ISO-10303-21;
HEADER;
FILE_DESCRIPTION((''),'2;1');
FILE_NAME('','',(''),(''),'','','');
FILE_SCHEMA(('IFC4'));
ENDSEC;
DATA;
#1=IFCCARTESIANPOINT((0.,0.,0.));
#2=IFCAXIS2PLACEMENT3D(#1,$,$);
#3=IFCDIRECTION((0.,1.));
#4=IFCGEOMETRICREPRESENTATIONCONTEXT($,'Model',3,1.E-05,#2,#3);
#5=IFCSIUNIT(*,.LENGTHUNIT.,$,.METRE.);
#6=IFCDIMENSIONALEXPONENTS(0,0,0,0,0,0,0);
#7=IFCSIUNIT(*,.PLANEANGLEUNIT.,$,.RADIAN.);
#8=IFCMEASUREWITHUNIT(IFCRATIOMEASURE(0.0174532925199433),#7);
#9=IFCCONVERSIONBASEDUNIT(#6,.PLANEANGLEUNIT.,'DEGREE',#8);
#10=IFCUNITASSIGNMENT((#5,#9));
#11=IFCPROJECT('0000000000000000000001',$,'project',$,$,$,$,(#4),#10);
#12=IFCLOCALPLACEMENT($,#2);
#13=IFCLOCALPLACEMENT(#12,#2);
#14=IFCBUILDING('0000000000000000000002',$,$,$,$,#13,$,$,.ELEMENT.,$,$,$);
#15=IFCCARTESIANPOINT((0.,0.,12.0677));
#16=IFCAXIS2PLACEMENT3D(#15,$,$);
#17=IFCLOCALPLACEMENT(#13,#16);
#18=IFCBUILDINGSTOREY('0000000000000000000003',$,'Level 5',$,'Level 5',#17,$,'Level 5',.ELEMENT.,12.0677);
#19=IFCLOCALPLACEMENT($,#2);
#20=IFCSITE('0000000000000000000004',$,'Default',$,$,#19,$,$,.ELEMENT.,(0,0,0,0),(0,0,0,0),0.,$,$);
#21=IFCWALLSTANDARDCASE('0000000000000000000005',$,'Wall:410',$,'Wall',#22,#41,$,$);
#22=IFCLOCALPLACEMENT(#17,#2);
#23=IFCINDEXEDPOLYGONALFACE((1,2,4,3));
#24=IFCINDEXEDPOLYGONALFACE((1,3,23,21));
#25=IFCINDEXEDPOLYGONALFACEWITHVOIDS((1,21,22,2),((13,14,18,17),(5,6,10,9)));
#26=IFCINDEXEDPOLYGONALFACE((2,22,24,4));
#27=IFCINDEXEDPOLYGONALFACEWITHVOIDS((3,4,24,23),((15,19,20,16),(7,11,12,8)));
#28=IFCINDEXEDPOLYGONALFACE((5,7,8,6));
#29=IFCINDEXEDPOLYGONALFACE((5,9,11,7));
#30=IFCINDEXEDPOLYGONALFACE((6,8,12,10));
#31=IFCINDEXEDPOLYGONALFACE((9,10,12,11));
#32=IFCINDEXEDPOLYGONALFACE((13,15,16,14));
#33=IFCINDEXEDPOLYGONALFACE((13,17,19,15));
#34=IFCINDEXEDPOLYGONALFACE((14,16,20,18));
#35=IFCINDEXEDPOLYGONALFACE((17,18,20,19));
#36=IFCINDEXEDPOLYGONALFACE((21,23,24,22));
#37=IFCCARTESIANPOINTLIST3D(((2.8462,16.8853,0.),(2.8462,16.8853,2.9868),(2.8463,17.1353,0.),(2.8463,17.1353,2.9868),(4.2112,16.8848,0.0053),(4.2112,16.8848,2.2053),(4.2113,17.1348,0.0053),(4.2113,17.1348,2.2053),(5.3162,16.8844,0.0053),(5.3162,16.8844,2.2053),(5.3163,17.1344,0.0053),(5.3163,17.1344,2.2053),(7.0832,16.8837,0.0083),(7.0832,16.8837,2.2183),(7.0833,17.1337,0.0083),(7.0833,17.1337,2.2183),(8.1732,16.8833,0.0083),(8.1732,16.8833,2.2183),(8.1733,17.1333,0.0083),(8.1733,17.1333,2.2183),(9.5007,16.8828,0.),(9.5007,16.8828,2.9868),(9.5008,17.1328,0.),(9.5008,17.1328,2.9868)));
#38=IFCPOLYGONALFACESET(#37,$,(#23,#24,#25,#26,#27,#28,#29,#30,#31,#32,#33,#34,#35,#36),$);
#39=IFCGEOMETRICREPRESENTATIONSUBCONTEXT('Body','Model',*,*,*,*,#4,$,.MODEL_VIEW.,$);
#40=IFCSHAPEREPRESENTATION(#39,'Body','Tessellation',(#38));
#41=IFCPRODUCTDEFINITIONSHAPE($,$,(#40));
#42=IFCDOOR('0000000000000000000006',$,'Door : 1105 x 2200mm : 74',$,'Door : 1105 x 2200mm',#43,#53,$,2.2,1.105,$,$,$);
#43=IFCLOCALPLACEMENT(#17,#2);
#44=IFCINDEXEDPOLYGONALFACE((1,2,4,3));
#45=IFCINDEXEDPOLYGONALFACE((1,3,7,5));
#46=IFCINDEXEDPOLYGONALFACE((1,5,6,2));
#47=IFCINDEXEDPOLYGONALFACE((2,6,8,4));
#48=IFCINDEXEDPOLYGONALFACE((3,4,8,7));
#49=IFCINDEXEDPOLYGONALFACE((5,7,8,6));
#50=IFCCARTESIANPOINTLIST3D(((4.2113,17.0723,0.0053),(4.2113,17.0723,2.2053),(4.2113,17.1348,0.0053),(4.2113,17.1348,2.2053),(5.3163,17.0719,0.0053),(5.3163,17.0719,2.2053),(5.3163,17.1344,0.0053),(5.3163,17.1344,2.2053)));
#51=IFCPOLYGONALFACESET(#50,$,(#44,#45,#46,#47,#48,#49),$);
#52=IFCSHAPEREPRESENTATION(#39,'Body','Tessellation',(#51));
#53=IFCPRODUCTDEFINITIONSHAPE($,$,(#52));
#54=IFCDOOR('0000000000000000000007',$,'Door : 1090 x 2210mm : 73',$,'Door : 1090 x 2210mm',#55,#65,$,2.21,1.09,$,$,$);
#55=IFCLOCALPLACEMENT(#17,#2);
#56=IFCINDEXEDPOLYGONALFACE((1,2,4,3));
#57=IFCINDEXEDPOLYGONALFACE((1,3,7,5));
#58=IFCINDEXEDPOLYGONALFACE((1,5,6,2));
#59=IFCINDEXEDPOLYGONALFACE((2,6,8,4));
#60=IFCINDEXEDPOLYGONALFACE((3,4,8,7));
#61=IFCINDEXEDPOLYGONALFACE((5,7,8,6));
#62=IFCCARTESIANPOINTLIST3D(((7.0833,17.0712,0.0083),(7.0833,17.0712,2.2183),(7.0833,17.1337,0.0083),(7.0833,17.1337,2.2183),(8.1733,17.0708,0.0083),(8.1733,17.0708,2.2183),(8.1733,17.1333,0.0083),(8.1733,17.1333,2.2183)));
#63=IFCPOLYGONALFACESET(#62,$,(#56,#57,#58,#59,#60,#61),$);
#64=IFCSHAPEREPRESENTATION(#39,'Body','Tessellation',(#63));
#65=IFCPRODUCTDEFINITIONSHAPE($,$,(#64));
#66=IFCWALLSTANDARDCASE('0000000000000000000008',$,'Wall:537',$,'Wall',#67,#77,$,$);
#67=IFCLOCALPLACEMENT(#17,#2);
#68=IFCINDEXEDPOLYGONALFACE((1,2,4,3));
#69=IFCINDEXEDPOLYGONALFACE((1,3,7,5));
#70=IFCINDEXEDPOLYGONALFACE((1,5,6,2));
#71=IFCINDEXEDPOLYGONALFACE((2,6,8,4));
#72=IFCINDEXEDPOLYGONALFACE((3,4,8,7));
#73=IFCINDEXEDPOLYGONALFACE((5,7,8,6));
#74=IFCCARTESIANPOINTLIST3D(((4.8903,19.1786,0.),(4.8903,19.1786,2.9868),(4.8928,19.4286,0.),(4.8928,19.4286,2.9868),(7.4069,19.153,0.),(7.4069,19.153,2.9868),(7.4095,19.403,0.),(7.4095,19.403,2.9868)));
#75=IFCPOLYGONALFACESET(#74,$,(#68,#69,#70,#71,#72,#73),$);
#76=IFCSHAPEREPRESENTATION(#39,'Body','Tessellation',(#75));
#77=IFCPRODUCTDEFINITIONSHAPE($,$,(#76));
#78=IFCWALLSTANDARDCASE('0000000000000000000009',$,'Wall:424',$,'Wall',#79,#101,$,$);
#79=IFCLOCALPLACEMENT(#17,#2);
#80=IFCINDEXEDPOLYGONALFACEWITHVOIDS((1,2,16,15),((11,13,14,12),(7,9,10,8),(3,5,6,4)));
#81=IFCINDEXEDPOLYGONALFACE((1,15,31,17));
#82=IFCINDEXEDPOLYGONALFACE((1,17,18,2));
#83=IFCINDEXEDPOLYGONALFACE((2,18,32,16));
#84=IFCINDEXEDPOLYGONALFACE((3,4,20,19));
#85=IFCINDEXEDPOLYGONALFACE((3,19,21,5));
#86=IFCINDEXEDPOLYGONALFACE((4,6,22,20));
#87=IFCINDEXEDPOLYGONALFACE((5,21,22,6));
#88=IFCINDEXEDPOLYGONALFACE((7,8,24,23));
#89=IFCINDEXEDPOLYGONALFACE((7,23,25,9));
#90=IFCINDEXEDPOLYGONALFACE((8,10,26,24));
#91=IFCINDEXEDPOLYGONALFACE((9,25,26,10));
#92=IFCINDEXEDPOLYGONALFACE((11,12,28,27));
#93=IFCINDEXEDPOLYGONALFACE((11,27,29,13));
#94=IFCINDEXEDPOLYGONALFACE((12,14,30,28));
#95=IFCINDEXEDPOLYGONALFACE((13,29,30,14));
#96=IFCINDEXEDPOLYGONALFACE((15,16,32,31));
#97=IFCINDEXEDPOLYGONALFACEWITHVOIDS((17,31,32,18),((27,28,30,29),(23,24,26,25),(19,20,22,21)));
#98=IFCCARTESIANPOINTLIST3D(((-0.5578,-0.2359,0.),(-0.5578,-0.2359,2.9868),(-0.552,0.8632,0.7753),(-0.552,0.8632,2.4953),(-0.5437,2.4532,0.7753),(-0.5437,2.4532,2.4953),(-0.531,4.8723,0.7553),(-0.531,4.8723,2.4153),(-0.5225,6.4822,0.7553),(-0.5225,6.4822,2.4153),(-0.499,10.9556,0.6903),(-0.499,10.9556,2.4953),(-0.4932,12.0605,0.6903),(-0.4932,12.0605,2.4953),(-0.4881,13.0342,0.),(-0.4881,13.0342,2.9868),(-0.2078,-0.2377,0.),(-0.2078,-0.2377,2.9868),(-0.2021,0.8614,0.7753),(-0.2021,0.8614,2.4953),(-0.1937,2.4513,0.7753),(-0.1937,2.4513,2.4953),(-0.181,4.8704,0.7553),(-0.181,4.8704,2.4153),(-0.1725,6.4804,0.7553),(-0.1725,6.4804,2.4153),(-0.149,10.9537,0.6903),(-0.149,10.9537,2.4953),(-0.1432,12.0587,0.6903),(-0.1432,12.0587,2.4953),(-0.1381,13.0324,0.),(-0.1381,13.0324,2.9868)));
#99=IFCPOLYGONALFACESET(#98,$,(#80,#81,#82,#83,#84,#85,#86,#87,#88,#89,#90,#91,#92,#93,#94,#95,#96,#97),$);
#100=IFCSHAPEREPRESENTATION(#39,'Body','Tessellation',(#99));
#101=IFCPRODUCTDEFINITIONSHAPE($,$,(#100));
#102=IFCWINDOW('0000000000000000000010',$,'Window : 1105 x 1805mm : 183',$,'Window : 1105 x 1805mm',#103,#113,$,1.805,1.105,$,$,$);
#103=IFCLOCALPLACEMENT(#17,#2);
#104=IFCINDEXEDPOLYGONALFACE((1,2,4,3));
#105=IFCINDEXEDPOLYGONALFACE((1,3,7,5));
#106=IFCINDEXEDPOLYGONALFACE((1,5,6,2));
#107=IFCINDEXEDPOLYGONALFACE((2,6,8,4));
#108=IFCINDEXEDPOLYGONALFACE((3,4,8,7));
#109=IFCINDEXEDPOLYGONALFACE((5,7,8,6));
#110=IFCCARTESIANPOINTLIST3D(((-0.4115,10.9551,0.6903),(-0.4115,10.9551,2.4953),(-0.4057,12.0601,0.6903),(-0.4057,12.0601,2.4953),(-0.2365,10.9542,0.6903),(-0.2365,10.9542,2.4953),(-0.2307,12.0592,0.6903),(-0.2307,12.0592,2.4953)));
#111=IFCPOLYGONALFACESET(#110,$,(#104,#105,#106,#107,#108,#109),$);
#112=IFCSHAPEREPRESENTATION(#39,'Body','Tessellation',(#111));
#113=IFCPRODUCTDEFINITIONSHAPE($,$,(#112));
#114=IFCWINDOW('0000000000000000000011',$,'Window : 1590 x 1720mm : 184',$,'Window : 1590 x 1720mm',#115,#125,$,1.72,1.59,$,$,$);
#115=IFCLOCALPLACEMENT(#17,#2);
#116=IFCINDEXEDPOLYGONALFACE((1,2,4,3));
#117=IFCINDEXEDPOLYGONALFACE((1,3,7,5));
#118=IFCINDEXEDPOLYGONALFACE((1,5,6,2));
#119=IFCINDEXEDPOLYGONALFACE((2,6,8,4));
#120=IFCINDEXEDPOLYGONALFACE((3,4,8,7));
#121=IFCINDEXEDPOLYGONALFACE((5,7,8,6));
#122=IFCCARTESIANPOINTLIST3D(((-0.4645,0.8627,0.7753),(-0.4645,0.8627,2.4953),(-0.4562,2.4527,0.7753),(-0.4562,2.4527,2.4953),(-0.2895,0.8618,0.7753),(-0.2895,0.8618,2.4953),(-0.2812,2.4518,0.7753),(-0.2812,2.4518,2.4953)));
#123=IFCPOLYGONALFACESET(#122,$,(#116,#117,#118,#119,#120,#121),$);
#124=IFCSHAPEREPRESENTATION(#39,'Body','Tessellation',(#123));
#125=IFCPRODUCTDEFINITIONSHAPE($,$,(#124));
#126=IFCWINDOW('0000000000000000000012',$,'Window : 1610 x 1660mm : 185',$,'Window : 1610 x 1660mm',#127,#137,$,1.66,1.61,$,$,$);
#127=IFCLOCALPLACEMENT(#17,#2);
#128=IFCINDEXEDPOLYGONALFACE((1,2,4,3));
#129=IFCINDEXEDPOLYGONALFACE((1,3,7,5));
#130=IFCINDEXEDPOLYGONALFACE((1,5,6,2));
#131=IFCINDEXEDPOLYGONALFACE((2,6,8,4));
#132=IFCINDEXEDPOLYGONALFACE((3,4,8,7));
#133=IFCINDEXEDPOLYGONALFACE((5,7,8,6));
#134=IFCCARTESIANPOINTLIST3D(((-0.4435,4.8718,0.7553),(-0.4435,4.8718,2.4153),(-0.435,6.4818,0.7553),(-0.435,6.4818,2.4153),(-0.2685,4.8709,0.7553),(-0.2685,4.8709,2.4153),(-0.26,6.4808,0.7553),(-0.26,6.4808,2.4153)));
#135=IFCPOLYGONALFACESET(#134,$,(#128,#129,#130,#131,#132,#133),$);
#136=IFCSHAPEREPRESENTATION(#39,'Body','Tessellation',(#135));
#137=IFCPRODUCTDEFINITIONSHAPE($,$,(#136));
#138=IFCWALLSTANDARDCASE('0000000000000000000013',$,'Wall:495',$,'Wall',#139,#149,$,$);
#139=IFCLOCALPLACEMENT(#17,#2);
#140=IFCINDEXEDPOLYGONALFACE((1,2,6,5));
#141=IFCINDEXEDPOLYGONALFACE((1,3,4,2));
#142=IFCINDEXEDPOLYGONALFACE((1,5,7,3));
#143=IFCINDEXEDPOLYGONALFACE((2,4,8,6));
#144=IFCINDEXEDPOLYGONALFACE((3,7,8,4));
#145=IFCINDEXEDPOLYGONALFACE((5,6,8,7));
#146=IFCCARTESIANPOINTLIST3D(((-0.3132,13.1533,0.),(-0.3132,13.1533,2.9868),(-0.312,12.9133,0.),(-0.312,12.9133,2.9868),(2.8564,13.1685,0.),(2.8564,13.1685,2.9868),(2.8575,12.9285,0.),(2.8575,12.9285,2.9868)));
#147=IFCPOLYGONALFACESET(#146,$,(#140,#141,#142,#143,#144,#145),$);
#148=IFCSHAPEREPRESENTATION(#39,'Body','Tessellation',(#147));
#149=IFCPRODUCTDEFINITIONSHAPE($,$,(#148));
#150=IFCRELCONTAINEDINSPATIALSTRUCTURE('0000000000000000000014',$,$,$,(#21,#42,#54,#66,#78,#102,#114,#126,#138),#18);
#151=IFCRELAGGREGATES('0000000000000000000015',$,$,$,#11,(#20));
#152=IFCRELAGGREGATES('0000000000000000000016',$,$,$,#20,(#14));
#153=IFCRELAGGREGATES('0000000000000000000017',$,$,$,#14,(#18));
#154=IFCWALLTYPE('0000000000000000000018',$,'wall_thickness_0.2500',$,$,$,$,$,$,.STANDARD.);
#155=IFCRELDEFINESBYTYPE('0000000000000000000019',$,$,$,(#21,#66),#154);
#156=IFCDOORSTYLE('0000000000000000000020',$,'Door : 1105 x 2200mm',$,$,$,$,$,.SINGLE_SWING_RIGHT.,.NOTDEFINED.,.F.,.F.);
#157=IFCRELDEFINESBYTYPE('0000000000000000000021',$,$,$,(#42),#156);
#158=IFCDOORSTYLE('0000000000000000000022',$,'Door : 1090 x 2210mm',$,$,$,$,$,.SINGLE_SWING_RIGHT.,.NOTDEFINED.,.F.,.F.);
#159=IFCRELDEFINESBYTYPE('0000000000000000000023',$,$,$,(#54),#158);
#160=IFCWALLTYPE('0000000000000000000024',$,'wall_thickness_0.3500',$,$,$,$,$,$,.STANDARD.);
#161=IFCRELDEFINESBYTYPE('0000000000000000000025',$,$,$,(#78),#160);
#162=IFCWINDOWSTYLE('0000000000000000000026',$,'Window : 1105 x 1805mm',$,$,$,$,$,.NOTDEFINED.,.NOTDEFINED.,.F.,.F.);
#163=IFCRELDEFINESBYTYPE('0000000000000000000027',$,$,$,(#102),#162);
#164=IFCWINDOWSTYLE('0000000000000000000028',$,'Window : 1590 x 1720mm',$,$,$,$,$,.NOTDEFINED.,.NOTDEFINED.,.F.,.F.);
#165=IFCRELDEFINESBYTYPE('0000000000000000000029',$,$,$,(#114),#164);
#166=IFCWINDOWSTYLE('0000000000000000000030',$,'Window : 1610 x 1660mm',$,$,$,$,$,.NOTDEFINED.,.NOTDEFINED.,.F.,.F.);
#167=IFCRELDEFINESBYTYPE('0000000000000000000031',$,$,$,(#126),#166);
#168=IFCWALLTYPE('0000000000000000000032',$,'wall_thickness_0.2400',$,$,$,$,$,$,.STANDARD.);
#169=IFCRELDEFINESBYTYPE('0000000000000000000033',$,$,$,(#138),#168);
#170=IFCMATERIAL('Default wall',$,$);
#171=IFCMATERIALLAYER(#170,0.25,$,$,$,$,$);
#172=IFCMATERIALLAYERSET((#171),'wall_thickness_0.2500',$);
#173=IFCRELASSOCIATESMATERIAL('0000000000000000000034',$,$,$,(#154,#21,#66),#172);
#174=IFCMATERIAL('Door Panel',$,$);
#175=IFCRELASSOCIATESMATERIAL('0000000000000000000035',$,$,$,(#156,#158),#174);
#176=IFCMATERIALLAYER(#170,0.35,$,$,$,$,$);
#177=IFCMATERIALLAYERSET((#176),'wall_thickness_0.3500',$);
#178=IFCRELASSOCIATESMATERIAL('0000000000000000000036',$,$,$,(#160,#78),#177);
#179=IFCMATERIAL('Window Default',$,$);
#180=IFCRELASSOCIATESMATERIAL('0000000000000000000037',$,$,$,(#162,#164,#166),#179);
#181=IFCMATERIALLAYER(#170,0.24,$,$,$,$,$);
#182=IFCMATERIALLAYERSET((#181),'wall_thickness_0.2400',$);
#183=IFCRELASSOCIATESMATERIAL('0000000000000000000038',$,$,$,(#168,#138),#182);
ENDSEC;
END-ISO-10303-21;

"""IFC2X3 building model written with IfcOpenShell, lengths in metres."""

from ifc_helpers import new_model, entity, si_unit, converted_unit, direction, frame, frame_2d, origin, origin_2d_with_axis, place, context, subcontext, project, spatial, polyline, rectangle, outline, extrude, source, transform, mapped, material, layer, layer_set, layer_usage, type_object, type_shapes, element, fill, save


model = new_model("IFC2X3")

# Units and contexts
model_context = context("Model", 3, precision=1e-05, world=origin(), true_north=direction((0.0, 1.0)))
body_context = subcontext(model_context, "Body", "Model", "MODEL_VIEW")
ifc_project = project(units=[si_unit("LENGTHUNIT", "METRE"), converted_unit("PLANEANGLEUNIT", "DEGREE", entity("IfcRatioMeasure", 0.0174532925199433), si_unit("PLANEANGLEUNIT", "RADIAN"), dimensions=[0, 0, 0, 0, 0, 0, 0])], contexts=[model_context])

# Site, building, storey
site_placement = place(None, origin())
site = spatial("IfcSite", under=ifc_project, at=site_placement, Name="Default", CompositionType="ELEMENT", RefLatitude=(0, 0, 0, 0), RefLongitude=(0, 0, 0, 0), RefElevation=0.0)
placement_1 = place(None, origin())
building_placement = place(placement_1, origin())
building = spatial("IfcBuilding", under=site, at=building_placement, CompositionType="ELEMENT")
storey_placement = place(building_placement, frame((0.0, 0.0, 12.0677)))
storey = spatial("IfcBuildingStorey", under=building, at=storey_placement, Name="Level 5", ObjectType="Level 5", LongName="Level 5", CompositionType="ELEMENT", Elevation=12.0677)

# Shared definitions
ifc_material_1 = material(Name="Default wall")

# Shared definitions
ifc_material_2 = material(Name="Window Default")

# Shared definitions
ifc_material_3 = material(Name="Door Panel")

# Wall, openings, doors
ifc_layer_1 = layer(ifc_material_1, 0.25)
ifc_layer_set_1 = layer_set([ifc_layer_1], Name="wall_thickness_0.2500")
ifc_layer_usage_1 = layer_usage(ifc_layer_set_1, "AXIS2", "POSITIVE", -0.125)
wall_type_1 = type_object("IfcWallType", Name="wall_thickness_0.2500", PredefinedType="STANDARD", material=ifc_layer_set_1)
wall_1_placement = place(storey_placement, frame((2.8463, 17.0103, 0.0), z_axis=(0.0, 0.0, 1.0), x_axis=(1.0, -0.000375, 0.0)))
wall_1 = element("IfcWallStandardCase", 1, at=wall_1_placement, inside=storey, type_object=wall_type_1, material=ifc_layer_usage_1, Name="Wall:410", ObjectType="Wall", context=body_context, shape_type="SweptSolid", body=[
    extrude(outline(polyline([(6.6545, -0.125), (6.6545, 0.125), (0.0, 0.125), (0.0, -0.125), (6.6545, -0.125)])), origin(), (0.0, 0.0, 1.0), 2.9868),
])
opening_1_placement = place(wall_1_placement, frame((4.237, -0.125, 0.0083)))
opening_1 = element("IfcOpeningElement", 2, at=opening_1_placement, cuts=wall_1, ObjectType="Opening", context=body_context, shape_type="SweptSolid", body=[
    extrude(rectangle(XDim=1.09, YDim=2.21, at=frame_2d((1.105, 0.545), x_axis=(0.0, 1.0))), frame((0.0, 0.0, 0.0), z_axis=(0.0, 1.0, 0.0), x_axis=(0.0, 0.0, 1.0)), (0.0, 0.0, 1.0), 0.25),
])
opening_2_placement = place(wall_1_placement, frame((1.365, -0.125, 0.0053)))
opening_2 = element("IfcOpeningElement", 3, at=opening_2_placement, cuts=wall_1, ObjectType="Opening", context=body_context, shape_type="SweptSolid", body=[
    extrude(rectangle(XDim=1.105, YDim=2.2, at=frame_2d((1.1, 0.5525), x_axis=(0.0, 1.0))), frame((0.0, 0.0, 0.0), z_axis=(0.0, 1.0, 0.0), x_axis=(0.0, 0.0, 1.0)), (0.0, 0.0, 1.0), 0.25),
])
door_style_1 = type_object("IfcDoorStyle", Name="Door : 1105 x 2200mm", ConstructionType="NOTDEFINED", OperationType="SINGLE_SWING_RIGHT", ParameterTakesPrecedence=False, Sizeable=False, material=ifc_material_3)
shared_shape_1 = source(origin(), body_context, "Body", "SweptSolid", [
    extrude(rectangle(XDim=0.0625, YDim=1.105, at=origin_2d_with_axis()), frame((0.5525, 0.2188, 0.0), z_axis=(0.0, 0.0, 1.0), x_axis=(0.0, 1.0, 0.0)), (0.0, 0.0, 1.0), 2.2),
])
type_shapes(door_style_1, [shared_shape_1])
door_1_placement = place(opening_2_placement, origin())
door_1 = element("IfcDoor", 4, at=door_1_placement, inside=storey, type_object=door_style_1, Name="Door : 1105 x 2200mm : 74", ObjectType="Door : 1105 x 2200mm", OverallHeight=2.2, OverallWidth=1.105, context=body_context, shape_type="MappedRepresentation", body=[
    mapped(shared_shape_1, transform((0.0, 0.0, 0.0), scale=1.0)),
])
fill(opening_2, door_1)
door_style_2 = type_object("IfcDoorStyle", Name="Door : 1090 x 2210mm", ConstructionType="NOTDEFINED", OperationType="SINGLE_SWING_RIGHT", ParameterTakesPrecedence=False, Sizeable=False, material=ifc_material_3)
shared_shape_2 = source(origin(), body_context, "Body", "SweptSolid", [
    extrude(rectangle(XDim=0.0625, YDim=1.09, at=origin_2d_with_axis()), frame((0.545, 0.2188, 0.0), z_axis=(0.0, 0.0, 1.0), x_axis=(0.0, 1.0, 0.0)), (0.0, 0.0, 1.0), 2.21),
])
type_shapes(door_style_2, [shared_shape_2])
door_2_placement = place(opening_1_placement, origin())
door_2 = element("IfcDoor", 5, at=door_2_placement, inside=storey, type_object=door_style_2, Name="Door : 1090 x 2210mm : 73", ObjectType="Door : 1090 x 2210mm", OverallHeight=2.21, OverallWidth=1.09, context=body_context, shape_type="MappedRepresentation", body=[
    mapped(shared_shape_2, transform((0.0, 0.0, 0.0), scale=1.0)),
])
fill(opening_1, door_2)

# Wall
wall_2_placement = place(storey_placement, frame((4.8915, 19.3036, 0.0), z_axis=(0.0, 0.0, 1.0), x_axis=(0.999948, -0.010172, 0.0)))
element("IfcWallStandardCase", 6, at=wall_2_placement, inside=storey, type_object=wall_type_1, material=ifc_layer_usage_1, Name="Wall:537", ObjectType="Wall", context=body_context, shape_type="SweptSolid", body=[
    extrude(outline(polyline([(2.5168, -0.125), (2.5168, 0.125), (0.0, 0.125), (0.0, -0.125), (2.5168, -0.125)])), origin(), (0.0, 0.0, 1.0), 2.9868),
])

# Wall, openings, windows
ifc_layer_2 = layer(ifc_material_1, 0.35)
ifc_layer_set_2 = layer_set([ifc_layer_2], Name="wall_thickness_0.3500")
ifc_layer_usage_2 = layer_usage(ifc_layer_set_2, "AXIS2", "POSITIVE", -0.175)
wall_type_2 = type_object("IfcWallType", Name="wall_thickness_0.3500", PredefinedType="STANDARD", material=ifc_layer_set_2)
wall_3_placement = place(storey_placement, frame((-0.3131, 13.0333, 0.0), z_axis=(0.0, 0.0, 1.0), x_axis=(-0.005256, -0.999986, 0.0)))
wall_3 = element("IfcWallStandardCase", 7, at=wall_3_placement, inside=storey, type_object=wall_type_2, material=ifc_layer_usage_2, Name="Wall:424", ObjectType="Wall", context=body_context, shape_type="SweptSolid", body=[
    extrude(outline(polyline([(13.2703, -0.175), (13.2703, 0.175), (0.0, 0.175), (0.0, -0.175), (13.2703, -0.175)])), origin(), (0.0, 0.0, 1.0), 2.9868),
])
opening_3_placement = place(wall_3_placement, frame((0.9737, -0.175, 0.6903)))
opening_3 = element("IfcOpeningElement", 8, at=opening_3_placement, cuts=wall_3, ObjectType="Opening", context=body_context, shape_type="SweptSolid", body=[
    extrude(rectangle(XDim=1.105, YDim=1.805, at=frame_2d((0.9025, 0.5525), x_axis=(0.0, 1.0))), frame((0.0, 0.0, 0.0), z_axis=(0.0, 1.0, 0.0), x_axis=(0.0, 0.0, 1.0)), (0.0, 0.0, 1.0), 0.35),
])
opening_4_placement = place(wall_3_placement, frame((10.5812, -0.175, 0.7753)))
opening_4 = element("IfcOpeningElement", 9, at=opening_4_placement, cuts=wall_3, ObjectType="Opening", context=body_context, shape_type="SweptSolid", body=[
    extrude(rectangle(XDim=1.59, YDim=1.72, at=frame_2d((0.86, 0.795), x_axis=(0.0, 1.0))), frame((0.0, 0.0, 0.0), z_axis=(0.0, 1.0, 0.0), x_axis=(0.0, 0.0, 1.0)), (0.0, 0.0, 1.0), 0.35),
])
opening_5_placement = place(wall_3_placement, frame((6.5521, -0.175, 0.7553)))
opening_5 = element("IfcOpeningElement", 10, at=opening_5_placement, cuts=wall_3, ObjectType="Opening", context=body_context, shape_type="SweptSolid", body=[
    extrude(rectangle(XDim=1.61, YDim=1.66, at=frame_2d((0.83, 0.805), x_axis=(0.0, 1.0))), frame((0.0, 0.0, 0.0), z_axis=(0.0, 1.0, 0.0), x_axis=(0.0, 0.0, 1.0)), (0.0, 0.0, 1.0), 0.35),
])
window_style_1 = type_object("IfcWindowStyle", Name="Window : 1105 x 1805mm", ConstructionType="NOTDEFINED", OperationType="NOTDEFINED", ParameterTakesPrecedence=False, Sizeable=False, material=ifc_material_2)
shared_shape_3 = source(origin(), body_context, "Body", "SweptSolid", [
    extrude(rectangle(XDim=0.175, YDim=1.105, at=origin_2d_with_axis()), frame((0.5525, 0.175, 0.0), z_axis=(0.0, 0.0, 1.0), x_axis=(0.0, 1.0, 0.0)), (0.0, 0.0, 1.0), 1.805),
])
type_shapes(window_style_1, [shared_shape_3])
window_1_placement = place(opening_3_placement, origin())
window_1 = element("IfcWindow", 11, at=window_1_placement, inside=storey, type_object=window_style_1, Name="Window : 1105 x 1805mm : 183", ObjectType="Window : 1105 x 1805mm", OverallHeight=1.805, OverallWidth=1.105, context=body_context, shape_type="MappedRepresentation", body=[
    mapped(shared_shape_3, transform((0.0, 0.0, 0.0), scale=1.0)),
])
fill(opening_3, window_1)
window_style_2 = type_object("IfcWindowStyle", Name="Window : 1590 x 1720mm", ConstructionType="NOTDEFINED", OperationType="NOTDEFINED", ParameterTakesPrecedence=False, Sizeable=False, material=ifc_material_2)
shared_shape_4 = source(origin(), body_context, "Body", "SweptSolid", [
    extrude(rectangle(XDim=0.175, YDim=1.59, at=origin_2d_with_axis()), frame((0.795, 0.175, 0.0), z_axis=(0.0, 0.0, 1.0), x_axis=(0.0, 1.0, 0.0)), (0.0, 0.0, 1.0), 1.72),
])
type_shapes(window_style_2, [shared_shape_4])
window_2_placement = place(opening_4_placement, origin())
window_2 = element("IfcWindow", 12, at=window_2_placement, inside=storey, type_object=window_style_2, Name="Window : 1590 x 1720mm : 184", ObjectType="Window : 1590 x 1720mm", OverallHeight=1.72, OverallWidth=1.59, context=body_context, shape_type="MappedRepresentation", body=[
    mapped(shared_shape_4, transform((0.0, 0.0, 0.0), scale=1.0)),
])
fill(opening_4, window_2)
window_style_3 = type_object("IfcWindowStyle", Name="Window : 1610 x 1660mm", ConstructionType="NOTDEFINED", OperationType="NOTDEFINED", ParameterTakesPrecedence=False, Sizeable=False, material=ifc_material_2)
shared_shape_5 = source(origin(), body_context, "Body", "SweptSolid", [
    extrude(rectangle(XDim=0.175, YDim=1.61, at=origin_2d_with_axis()), frame((0.805, 0.175, 0.0), z_axis=(0.0, 0.0, 1.0), x_axis=(0.0, 1.0, 0.0)), (0.0, 0.0, 1.0), 1.66),
])
type_shapes(window_style_3, [shared_shape_5])
window_3_placement = place(opening_5_placement, origin())
window_3 = element("IfcWindow", 13, at=window_3_placement, inside=storey, type_object=window_style_3, Name="Window : 1610 x 1660mm : 185", ObjectType="Window : 1610 x 1660mm", OverallHeight=1.66, OverallWidth=1.61, context=body_context, shape_type="MappedRepresentation", body=[
    mapped(shared_shape_5, transform((0.0, 0.0, 0.0), scale=1.0)),
])
fill(opening_5, window_3)

# Wall
ifc_layer_3 = layer(ifc_material_1, 0.24)
ifc_layer_set_3 = layer_set([ifc_layer_3], Name="wall_thickness_0.2400")
ifc_layer_usage_3 = layer_usage(ifc_layer_set_3, "AXIS2", "POSITIVE", -0.12)
wall_type_3 = type_object("IfcWallType", Name="wall_thickness_0.2400", PredefinedType="STANDARD", material=ifc_layer_set_3)
wall_4_placement = place(storey_placement, frame((-0.3126, 13.0333, 0.0), z_axis=(0.0, 0.0, 1.0), x_axis=(0.999988, 0.004797, 0.0)))
element("IfcWallStandardCase", 14, at=wall_4_placement, inside=storey, type_object=wall_type_3, material=ifc_layer_usage_3, Name="Wall:495", ObjectType="Wall", context=body_context, shape_type="SweptSolid", body=[
    extrude(outline(polyline([(3.1696, -0.12), (3.1696, 0.12), (0.0, 0.12), (0.0, -0.12), (3.1696, -0.12)])), origin(), (0.0, 0.0, 1.0), 2.9868),
])

save(model, "model.ifc")
